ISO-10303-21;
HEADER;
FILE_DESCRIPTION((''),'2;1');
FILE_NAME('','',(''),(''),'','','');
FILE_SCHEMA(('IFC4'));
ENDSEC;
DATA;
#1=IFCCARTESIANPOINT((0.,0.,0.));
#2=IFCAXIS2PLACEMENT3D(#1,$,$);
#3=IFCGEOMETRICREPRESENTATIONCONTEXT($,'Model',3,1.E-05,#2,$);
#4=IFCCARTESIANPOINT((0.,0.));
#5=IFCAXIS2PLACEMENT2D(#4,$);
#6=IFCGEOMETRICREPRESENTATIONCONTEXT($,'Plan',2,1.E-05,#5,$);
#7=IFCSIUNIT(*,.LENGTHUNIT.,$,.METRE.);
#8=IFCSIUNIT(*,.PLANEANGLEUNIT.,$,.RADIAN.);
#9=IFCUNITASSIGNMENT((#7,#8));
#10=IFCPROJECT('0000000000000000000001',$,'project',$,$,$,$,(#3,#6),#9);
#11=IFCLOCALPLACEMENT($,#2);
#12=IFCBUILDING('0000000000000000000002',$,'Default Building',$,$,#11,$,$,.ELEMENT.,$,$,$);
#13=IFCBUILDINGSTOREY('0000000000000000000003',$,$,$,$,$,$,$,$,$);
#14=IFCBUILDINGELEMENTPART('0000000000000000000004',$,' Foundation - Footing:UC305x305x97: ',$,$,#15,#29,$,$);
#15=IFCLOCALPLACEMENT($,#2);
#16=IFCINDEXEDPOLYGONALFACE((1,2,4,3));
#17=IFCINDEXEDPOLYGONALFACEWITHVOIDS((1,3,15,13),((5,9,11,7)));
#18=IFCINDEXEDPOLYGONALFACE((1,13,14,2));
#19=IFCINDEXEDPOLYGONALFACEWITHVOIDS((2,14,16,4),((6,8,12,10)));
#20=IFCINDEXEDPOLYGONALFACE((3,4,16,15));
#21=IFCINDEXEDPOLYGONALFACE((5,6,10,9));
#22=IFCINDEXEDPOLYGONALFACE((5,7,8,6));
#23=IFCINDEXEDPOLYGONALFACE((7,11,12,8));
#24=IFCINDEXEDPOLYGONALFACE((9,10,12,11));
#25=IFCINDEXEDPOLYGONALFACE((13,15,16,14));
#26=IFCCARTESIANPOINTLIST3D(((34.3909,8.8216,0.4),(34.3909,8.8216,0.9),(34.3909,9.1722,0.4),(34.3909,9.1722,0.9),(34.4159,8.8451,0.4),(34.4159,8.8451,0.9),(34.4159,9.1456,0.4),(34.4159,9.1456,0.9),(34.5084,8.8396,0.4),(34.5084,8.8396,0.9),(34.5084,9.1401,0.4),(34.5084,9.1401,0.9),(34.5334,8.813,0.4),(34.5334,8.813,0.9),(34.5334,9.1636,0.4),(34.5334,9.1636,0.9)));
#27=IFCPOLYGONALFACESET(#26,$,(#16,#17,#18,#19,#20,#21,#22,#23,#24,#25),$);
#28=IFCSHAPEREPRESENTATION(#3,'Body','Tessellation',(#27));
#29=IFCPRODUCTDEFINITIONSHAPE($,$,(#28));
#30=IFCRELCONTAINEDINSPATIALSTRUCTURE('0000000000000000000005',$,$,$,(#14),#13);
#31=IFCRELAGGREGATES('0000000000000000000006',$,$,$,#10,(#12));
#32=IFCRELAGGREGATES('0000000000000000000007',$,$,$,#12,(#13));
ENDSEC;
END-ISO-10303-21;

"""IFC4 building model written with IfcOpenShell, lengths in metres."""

from ifc_helpers import new_model, si_unit, origin, origin_2d, place, context, project, spatial, polyline, outline, extrude, element, save


model = new_model("IFC4")

# Units and contexts
model_context = context("Model", 3, precision=1e-05, world=origin())
plan_context = context("Plan", 2, precision=1e-05, world=origin_2d())
ifc_project = project(units=[si_unit("LENGTHUNIT", "METRE"), si_unit("PLANEANGLEUNIT", "RADIAN")], contexts=[model_context, plan_context])

# Building, storey
building_placement = place(None, origin())
building = spatial("IfcBuilding", under=ifc_project, at=building_placement, Name="Default Building", CompositionType="ELEMENT")
storey = spatial("IfcBuildingStorey", under=building)

# Building element part, opening
building_element_part_1 = element("IfcBuildingElementPart", 1, inside=storey, Name=" Foundation - Footing:UC305x305x97: ", context=model_context, shape_type="SweptSolid", body=[
    extrude(outline(polyline([(34.3909, 8.8216, 0.4), (34.5334, 8.813, 0.4), (34.5334, 9.1636, 0.4), (34.3909, 9.1722, 0.4), (34.3909, 8.8216, 0.4)])), None, (0.0, 0.0, 1.0), 0.5),
])
element("IfcOpeningElement", 2, inside=storey, cuts=building_element_part_1, context=model_context, shape_type="SweptSolid", body=[
    extrude(outline(polyline([(34.4159, 8.8451, 0.4), (34.5084, 8.8396, 0.4), (34.5084, 9.1401, 0.4), (34.4159, 9.1456, 0.4), (34.4159, 8.8451, 0.4)])), None, (0.0, 0.0, 1.0), 0.5),
])

save(model, "model.ifc")
